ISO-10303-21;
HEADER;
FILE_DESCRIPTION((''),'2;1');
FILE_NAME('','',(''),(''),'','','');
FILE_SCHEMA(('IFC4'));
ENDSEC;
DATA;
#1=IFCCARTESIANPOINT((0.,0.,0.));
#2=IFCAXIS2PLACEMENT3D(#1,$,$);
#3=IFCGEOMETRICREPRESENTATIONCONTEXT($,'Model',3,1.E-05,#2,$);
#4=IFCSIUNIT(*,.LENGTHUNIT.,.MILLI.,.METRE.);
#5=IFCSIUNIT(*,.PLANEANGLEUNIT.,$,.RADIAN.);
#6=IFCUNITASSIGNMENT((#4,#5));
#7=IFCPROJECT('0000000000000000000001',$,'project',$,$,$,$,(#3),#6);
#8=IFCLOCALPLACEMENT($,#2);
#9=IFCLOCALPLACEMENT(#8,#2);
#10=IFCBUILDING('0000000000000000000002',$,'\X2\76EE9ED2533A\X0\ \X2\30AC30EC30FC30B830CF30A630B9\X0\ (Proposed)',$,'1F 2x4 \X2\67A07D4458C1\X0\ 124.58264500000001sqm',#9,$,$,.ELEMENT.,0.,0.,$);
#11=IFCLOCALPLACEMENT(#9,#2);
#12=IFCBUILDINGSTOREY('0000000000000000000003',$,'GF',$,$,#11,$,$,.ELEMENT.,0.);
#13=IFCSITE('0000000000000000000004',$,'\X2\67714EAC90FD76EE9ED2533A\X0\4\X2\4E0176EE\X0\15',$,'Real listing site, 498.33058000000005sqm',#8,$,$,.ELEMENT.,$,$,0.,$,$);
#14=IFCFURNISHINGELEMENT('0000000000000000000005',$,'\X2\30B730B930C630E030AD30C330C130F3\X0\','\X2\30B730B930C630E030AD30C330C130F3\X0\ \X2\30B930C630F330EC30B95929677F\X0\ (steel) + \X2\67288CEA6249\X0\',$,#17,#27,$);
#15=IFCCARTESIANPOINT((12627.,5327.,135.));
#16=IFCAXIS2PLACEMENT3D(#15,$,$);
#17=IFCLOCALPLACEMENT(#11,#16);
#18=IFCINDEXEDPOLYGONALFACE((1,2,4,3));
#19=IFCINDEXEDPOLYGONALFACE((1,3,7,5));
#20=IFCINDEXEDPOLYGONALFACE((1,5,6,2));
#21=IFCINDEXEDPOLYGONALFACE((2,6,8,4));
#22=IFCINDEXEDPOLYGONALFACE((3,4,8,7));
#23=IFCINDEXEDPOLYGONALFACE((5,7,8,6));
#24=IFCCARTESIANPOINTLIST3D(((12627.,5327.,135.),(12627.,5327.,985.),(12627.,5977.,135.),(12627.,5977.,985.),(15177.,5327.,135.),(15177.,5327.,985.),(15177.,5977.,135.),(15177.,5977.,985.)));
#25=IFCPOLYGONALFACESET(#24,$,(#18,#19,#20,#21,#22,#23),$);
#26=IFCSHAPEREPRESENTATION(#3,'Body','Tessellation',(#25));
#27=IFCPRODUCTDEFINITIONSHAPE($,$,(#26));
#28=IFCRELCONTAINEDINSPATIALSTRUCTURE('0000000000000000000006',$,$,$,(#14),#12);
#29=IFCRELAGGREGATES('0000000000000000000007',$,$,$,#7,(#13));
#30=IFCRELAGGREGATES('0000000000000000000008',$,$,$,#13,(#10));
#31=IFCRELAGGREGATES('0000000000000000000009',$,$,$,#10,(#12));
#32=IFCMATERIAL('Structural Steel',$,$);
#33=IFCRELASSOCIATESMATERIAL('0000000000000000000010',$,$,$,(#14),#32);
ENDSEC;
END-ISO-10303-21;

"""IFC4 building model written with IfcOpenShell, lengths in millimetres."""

from ifc_helpers import new_model, si_unit, frame, frame_2d, origin, place, context, project, spatial, rectangle, extrude, material, element, save


model = new_model("IFC4")

# Units and contexts
model_context = context("Model", 3, precision=1e-05, world=origin())
ifc_project = project(units=[si_unit("LENGTHUNIT", "METRE", prefix="MILLI"), si_unit("PLANEANGLEUNIT", "RADIAN")], contexts=[model_context])

# Site, building, storey
site_placement = place(None, origin())
site = spatial("IfcSite", under=ifc_project, at=site_placement, Name="東京都目黒区4丁目15", ObjectType="Real listing site, 498.33058000000005sqm", CompositionType="ELEMENT", RefElevation=0.0)
building_placement = place(site_placement, origin())
building = spatial("IfcBuilding", under=site, at=building_placement, Name="目黒区 ガレージハウス (Proposed)", ObjectType="1F 2x4 枠組壁 124.58264500000001sqm", CompositionType="ELEMENT", ElevationOfRefHeight=0.0, ElevationOfTerrain=0.0)
storey_placement = place(building_placement, origin())
storey = spatial("IfcBuildingStorey", under=building, at=storey_placement, Name="GF", CompositionType="ELEMENT", Elevation=0.0)

# Shared definitions
ifc_material_1 = material(Name="Structural Steel")

# Furnishing element
furnishing_1_placement = place(storey_placement, frame((12627.0, 5327.0, 135.0)))
element("IfcFurnishingElement", 1, at=furnishing_1_placement, inside=storey, material=ifc_material_1, Name="システムキッチン", Description="システムキッチン ステンレス天板 (steel) + 木質扉", context=model_context, shape_type="SweptSolid", body=[
    extrude(rectangle(XDim=2550.0, YDim=650.0, at=frame_2d((1275.0, 325.0))), frame((12627.0, 5327.0, 135.0)), (0.0, 0.0, 1.0), 850.0),
])

save(model, "model.ifc")
